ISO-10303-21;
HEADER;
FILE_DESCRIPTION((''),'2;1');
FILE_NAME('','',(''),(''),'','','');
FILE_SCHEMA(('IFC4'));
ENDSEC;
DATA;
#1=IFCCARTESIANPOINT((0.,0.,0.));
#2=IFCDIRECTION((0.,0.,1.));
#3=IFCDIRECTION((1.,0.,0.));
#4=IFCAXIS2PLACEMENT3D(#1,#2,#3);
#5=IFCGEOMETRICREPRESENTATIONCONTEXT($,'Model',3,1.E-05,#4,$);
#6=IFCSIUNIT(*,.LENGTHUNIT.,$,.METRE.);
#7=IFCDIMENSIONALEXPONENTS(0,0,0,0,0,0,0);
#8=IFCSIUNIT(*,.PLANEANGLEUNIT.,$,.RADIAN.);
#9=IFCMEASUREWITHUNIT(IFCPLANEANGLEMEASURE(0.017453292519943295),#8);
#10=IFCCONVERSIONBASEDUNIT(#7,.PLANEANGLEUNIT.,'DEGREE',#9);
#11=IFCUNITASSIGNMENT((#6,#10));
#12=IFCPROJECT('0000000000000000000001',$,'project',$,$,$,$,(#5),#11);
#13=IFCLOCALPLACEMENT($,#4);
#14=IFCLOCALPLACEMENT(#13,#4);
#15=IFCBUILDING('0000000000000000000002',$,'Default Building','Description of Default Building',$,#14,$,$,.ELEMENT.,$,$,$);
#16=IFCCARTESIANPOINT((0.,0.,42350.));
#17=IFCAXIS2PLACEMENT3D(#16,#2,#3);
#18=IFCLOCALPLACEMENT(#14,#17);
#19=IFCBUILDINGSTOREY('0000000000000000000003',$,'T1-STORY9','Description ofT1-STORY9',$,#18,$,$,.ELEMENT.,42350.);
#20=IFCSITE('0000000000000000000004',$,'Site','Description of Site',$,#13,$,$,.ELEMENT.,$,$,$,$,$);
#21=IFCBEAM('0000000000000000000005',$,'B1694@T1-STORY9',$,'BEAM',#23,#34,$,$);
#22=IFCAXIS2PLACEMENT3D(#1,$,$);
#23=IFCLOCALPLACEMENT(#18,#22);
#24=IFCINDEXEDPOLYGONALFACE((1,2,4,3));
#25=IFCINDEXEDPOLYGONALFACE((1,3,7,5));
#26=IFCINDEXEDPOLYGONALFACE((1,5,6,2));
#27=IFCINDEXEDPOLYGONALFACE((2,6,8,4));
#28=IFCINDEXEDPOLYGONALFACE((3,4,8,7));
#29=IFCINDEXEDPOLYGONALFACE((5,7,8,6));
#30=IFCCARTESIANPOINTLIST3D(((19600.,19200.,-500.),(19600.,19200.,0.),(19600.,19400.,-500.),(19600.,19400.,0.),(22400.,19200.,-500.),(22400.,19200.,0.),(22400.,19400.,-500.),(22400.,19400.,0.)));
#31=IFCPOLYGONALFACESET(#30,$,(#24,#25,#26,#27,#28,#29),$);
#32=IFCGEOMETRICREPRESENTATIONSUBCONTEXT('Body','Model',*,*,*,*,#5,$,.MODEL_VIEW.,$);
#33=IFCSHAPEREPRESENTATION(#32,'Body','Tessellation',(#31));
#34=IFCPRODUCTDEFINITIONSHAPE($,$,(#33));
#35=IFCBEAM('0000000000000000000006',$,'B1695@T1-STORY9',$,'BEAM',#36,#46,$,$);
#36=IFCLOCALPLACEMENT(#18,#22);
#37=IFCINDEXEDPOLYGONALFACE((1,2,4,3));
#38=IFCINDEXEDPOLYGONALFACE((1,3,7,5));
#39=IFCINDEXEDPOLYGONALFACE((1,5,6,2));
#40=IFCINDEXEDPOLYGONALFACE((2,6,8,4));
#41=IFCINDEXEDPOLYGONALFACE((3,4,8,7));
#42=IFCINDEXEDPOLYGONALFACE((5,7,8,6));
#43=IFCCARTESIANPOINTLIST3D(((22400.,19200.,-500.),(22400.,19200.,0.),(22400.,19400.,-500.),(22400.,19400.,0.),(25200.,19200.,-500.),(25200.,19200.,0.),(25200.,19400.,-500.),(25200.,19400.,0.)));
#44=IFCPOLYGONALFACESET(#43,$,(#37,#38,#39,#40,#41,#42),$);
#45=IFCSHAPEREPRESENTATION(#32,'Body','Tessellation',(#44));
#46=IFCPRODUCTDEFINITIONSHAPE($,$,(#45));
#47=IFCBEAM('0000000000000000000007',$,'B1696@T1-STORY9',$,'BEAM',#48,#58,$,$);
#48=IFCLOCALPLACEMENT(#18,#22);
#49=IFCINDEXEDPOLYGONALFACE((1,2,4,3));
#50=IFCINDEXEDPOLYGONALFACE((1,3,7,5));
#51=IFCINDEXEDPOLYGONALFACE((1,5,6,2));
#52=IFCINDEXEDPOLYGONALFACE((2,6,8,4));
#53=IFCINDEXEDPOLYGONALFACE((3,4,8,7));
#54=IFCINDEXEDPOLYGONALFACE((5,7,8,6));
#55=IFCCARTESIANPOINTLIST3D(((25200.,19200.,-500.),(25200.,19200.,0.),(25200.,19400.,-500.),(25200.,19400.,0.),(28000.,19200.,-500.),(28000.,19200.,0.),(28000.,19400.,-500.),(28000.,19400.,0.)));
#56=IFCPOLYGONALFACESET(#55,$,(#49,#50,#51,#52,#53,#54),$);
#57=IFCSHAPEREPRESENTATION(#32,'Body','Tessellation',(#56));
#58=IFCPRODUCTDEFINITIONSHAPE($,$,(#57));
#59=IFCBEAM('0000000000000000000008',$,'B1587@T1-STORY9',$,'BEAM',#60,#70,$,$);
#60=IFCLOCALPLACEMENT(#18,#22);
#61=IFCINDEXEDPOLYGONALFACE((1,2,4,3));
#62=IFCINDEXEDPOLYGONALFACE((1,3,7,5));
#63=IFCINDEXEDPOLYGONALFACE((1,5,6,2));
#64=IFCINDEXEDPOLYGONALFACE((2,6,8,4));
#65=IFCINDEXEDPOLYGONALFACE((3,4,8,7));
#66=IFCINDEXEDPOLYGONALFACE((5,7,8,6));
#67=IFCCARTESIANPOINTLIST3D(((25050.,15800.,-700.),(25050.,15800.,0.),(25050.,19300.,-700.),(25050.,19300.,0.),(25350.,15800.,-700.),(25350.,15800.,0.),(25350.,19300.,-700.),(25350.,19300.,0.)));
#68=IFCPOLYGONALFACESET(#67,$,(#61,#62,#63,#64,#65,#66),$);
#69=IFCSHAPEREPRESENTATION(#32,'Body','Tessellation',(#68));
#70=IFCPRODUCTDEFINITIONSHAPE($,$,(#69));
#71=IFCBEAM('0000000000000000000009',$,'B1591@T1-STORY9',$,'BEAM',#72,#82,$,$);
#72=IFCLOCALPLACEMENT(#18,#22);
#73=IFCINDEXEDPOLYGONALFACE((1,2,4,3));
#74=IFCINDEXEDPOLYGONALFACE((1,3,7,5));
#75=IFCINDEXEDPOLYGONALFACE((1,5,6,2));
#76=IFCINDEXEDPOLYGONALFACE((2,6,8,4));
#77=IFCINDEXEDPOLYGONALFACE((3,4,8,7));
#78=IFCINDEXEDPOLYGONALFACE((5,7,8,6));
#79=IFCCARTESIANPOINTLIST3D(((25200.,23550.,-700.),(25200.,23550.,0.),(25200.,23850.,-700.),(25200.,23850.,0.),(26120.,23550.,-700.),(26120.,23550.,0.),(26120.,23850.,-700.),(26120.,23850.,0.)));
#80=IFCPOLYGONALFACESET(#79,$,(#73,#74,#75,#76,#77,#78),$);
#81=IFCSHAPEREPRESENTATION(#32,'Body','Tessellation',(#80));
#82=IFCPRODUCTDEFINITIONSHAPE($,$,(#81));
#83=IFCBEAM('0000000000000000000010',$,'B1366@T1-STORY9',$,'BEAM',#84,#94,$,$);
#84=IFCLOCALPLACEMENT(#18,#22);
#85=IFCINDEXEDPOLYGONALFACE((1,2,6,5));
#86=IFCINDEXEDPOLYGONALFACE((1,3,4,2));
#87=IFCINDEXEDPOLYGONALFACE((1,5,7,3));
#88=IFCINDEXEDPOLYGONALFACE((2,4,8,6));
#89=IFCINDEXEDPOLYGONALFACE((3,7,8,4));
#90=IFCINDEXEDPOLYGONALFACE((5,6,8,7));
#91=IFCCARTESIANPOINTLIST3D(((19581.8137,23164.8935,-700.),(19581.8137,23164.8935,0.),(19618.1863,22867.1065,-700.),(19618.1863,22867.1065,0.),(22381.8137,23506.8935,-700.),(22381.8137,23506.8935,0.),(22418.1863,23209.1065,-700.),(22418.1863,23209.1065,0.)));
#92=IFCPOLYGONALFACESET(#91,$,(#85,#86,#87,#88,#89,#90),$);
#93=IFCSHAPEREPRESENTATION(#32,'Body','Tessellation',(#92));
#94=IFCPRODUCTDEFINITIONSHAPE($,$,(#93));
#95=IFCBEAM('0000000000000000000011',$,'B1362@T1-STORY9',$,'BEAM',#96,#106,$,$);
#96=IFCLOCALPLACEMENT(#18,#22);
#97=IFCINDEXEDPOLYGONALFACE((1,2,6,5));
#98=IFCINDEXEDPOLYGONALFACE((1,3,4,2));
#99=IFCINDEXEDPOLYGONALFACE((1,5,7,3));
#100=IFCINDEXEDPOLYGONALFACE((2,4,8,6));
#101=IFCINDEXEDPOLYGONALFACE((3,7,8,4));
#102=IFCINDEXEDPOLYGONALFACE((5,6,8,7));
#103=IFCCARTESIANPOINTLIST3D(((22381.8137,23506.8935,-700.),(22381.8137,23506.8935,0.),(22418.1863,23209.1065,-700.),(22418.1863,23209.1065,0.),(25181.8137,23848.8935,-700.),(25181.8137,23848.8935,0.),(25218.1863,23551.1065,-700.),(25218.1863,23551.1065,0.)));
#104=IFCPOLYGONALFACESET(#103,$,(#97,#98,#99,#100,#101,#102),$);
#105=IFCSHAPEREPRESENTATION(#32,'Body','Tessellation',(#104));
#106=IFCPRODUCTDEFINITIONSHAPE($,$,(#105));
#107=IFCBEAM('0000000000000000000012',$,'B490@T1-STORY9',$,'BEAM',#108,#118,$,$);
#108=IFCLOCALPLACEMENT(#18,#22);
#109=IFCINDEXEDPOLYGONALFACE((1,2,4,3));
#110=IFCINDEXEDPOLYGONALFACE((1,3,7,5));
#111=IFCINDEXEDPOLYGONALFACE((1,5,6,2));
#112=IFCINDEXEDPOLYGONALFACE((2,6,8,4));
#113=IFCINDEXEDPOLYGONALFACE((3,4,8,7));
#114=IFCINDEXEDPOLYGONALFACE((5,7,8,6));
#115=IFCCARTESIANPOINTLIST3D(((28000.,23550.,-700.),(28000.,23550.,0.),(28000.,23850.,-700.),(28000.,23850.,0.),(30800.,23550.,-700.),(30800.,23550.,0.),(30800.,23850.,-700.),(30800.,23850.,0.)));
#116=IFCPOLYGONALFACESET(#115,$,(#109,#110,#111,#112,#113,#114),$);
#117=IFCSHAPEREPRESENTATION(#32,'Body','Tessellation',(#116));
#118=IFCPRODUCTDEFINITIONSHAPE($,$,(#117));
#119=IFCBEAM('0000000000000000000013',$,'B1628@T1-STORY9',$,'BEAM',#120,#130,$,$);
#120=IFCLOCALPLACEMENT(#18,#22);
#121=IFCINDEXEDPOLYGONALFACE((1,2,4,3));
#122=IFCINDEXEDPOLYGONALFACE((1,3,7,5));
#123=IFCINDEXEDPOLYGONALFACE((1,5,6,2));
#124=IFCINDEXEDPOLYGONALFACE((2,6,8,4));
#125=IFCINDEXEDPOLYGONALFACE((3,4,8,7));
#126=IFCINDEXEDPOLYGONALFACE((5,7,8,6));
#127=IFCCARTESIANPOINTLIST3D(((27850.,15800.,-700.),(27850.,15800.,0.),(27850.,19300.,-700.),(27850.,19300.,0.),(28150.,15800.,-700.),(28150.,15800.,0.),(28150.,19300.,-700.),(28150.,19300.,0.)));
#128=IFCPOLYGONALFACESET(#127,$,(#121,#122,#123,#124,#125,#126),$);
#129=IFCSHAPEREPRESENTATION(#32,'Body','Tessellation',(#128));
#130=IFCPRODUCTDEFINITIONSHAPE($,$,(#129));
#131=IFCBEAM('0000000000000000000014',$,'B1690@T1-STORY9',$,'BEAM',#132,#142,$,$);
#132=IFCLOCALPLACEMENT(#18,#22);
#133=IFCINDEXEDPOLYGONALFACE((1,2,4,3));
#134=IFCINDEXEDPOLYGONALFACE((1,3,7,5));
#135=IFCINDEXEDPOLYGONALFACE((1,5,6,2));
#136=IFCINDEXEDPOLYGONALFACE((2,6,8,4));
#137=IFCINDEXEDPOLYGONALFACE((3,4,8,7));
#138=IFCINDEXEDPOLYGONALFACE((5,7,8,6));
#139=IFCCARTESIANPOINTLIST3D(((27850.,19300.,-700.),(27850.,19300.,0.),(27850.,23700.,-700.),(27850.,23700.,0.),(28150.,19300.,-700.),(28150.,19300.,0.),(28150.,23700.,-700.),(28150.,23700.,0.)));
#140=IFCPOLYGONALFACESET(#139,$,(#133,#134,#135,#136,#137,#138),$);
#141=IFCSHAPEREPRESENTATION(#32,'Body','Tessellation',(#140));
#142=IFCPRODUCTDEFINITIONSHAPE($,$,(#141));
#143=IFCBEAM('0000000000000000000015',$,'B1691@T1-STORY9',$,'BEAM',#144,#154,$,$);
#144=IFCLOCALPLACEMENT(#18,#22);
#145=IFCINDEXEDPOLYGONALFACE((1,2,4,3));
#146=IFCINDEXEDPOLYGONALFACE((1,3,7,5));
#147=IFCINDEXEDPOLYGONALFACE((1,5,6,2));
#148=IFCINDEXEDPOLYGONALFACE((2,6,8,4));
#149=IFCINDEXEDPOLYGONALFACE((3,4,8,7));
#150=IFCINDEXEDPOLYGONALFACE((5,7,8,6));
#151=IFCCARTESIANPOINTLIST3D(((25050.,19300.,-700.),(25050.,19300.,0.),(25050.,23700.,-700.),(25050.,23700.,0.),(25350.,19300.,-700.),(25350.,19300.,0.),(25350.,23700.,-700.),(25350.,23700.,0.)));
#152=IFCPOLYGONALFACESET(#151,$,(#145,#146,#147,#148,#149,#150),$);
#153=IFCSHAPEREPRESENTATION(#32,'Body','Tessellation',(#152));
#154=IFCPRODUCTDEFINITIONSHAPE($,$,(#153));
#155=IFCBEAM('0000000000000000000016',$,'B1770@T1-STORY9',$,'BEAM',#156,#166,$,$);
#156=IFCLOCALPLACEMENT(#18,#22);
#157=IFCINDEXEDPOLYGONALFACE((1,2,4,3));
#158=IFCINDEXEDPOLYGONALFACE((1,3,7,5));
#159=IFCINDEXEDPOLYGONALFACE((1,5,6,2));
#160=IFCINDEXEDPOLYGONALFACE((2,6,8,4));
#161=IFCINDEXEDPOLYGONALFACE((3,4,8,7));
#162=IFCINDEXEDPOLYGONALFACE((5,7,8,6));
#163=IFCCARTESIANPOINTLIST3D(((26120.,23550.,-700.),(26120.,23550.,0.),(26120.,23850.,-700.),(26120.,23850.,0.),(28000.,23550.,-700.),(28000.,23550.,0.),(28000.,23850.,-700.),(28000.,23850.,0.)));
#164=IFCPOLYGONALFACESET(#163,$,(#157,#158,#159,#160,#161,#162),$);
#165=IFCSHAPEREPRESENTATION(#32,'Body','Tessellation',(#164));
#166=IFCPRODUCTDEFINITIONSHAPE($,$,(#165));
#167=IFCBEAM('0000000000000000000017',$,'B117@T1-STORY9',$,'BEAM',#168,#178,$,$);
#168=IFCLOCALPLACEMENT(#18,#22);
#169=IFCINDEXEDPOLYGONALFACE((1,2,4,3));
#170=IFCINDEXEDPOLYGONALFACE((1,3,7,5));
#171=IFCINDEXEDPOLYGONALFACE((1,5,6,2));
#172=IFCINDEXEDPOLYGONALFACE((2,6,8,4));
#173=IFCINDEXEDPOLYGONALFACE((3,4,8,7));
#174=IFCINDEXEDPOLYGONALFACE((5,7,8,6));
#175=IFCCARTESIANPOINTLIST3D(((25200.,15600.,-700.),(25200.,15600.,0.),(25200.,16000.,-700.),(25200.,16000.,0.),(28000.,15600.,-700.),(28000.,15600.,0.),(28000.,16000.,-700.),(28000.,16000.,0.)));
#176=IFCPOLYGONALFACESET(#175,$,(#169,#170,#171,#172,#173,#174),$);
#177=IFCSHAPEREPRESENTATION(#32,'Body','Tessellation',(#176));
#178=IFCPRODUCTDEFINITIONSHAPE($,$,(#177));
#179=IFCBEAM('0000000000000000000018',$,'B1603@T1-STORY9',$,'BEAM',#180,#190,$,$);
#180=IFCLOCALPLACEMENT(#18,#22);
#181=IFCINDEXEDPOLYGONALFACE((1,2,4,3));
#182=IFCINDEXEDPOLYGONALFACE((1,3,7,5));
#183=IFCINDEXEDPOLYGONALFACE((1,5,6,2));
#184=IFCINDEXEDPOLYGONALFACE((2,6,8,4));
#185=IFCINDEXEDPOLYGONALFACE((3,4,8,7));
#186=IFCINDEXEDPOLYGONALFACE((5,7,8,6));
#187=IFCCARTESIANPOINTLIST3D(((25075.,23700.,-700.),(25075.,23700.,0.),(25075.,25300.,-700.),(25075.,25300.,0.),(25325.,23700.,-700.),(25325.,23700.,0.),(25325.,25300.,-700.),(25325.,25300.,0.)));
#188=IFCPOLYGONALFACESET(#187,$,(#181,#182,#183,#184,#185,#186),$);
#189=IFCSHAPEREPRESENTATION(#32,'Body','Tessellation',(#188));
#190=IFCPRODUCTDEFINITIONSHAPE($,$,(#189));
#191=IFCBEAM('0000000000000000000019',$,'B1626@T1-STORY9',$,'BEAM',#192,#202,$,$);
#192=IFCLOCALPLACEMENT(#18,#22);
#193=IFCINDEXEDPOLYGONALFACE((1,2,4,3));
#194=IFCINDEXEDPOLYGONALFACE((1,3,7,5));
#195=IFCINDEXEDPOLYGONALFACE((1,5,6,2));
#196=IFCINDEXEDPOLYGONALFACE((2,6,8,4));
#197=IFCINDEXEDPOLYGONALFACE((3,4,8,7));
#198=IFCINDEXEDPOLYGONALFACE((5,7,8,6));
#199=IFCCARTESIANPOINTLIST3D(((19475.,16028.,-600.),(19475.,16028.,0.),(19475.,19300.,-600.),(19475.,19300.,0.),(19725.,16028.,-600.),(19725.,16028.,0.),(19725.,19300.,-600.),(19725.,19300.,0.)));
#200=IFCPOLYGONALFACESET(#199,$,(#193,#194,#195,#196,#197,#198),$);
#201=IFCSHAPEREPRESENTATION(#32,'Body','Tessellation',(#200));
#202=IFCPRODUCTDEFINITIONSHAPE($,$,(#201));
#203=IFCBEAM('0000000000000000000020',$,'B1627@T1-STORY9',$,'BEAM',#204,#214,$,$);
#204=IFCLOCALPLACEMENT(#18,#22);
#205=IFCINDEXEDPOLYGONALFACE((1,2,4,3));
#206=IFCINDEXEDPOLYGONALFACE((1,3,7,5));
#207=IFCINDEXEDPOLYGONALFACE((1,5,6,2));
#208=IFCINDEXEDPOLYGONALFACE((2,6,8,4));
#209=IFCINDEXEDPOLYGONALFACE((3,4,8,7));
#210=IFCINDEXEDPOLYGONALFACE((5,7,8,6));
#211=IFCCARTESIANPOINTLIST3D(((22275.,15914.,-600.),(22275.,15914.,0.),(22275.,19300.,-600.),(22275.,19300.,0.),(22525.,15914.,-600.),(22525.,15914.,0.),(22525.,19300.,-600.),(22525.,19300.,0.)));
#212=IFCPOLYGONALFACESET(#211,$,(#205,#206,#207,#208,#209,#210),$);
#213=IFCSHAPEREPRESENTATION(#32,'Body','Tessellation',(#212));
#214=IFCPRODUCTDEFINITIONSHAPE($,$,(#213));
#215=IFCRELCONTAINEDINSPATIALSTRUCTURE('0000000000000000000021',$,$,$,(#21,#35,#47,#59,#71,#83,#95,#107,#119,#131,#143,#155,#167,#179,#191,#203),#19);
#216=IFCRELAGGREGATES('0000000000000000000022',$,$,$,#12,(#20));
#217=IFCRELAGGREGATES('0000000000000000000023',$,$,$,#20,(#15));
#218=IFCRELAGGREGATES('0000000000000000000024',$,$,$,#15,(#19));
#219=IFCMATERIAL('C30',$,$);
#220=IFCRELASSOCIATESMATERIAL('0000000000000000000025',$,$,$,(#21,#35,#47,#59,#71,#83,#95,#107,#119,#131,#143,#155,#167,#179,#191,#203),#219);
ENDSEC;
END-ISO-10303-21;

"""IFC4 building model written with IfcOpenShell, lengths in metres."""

from ifc_helpers import new_model, entity, si_unit, converted_unit, frame, origin_with_axes, place, context, subcontext, project, spatial, rectangle, extrude, material, element, save


model = new_model("IFC4")

# Units and contexts
model_context = context("Model", 3, precision=1e-05, world=origin_with_axes())
body_context = subcontext(model_context, "Body", "Model", "MODEL_VIEW")
ifc_project = project(units=[si_unit("LENGTHUNIT", "METRE"), converted_unit("PLANEANGLEUNIT", "DEGREE", entity("IfcPlaneAngleMeasure", 0.017453292519943295), si_unit("PLANEANGLEUNIT", "RADIAN"), dimensions=[0, 0, 0, 0, 0, 0, 0])], contexts=[model_context])

# Site, building, storey
site_placement = place(None, origin_with_axes())
site = spatial("IfcSite", under=ifc_project, at=site_placement, Name="Site", Description="Description of Site", CompositionType="ELEMENT")
building_placement = place(site_placement, origin_with_axes())
building = spatial("IfcBuilding", under=site, at=building_placement, Name="Default Building", Description="Description of Default Building", CompositionType="ELEMENT")
storey_placement = place(building_placement, frame((0.0, 0.0, 42350.0), z_axis=(0.0, 0.0, 1.0), x_axis=(1.0, 0.0, 0.0)))
storey = spatial("IfcBuildingStorey", under=building, at=storey_placement, Name="T1-STORY9", Description="Description ofT1-STORY9", CompositionType="ELEMENT", Elevation=42350.0)

# Beams
ifc_material_1 = material(Name="C30")
for number, where, z_axis, x_axis, name in (
    (1, (19600.0, 19300.0, -250.0), (1.0, 0.0, 0.0), (0.0, 1.0, 0.0), "B1694@T1-STORY9"),
    (2, (22400.0, 19300.0, -250.0), (1.0, 0.0, 0.0), (0.0, 1.0, 0.0), "B1695@T1-STORY9"),
    (3, (25200.0, 19300.0, -250.0), (1.0, 0.0, 0.0), (0.0, 1.0, 0.0), "B1696@T1-STORY9"),
):
    element("IfcBeam", number, at=place(storey_placement, frame(where, z_axis=z_axis, x_axis=x_axis)), inside=storey, material=ifc_material_1, Name=name, ObjectType="BEAM", context=body_context, shape_type="SweptSolid", body=[
        extrude(rectangle(XDim=200.0, YDim=500.0), origin_with_axes(), (0.0, 0.0, 1.0), 2800.0),
    ])
beam_1_placement = place(storey_placement, frame((25200.0, 15800.0, -350.0), z_axis=(0.0, 1.0, 0.0), x_axis=(-1.0, 0.0, 0.0)))
element("IfcBeam", 4, at=beam_1_placement, inside=storey, material=ifc_material_1, Name="B1587@T1-STORY9", ObjectType="BEAM", context=body_context, shape_type="SweptSolid", body=[
    extrude(rectangle(XDim=300.0, YDim=700.0), origin_with_axes(), (0.0, 0.0, 1.0), 3500.0),
])
beam_2_placement = place(storey_placement, frame((25200.0, 23700.0, -350.0), z_axis=(1.0, 0.0, 0.0), x_axis=(0.0, 1.0, 0.0)))
element("IfcBeam", 5, at=beam_2_placement, inside=storey, material=ifc_material_1, Name="B1591@T1-STORY9", ObjectType="BEAM", context=body_context, shape_type="SweptSolid", body=[
    extrude(rectangle(XDim=300.0, YDim=700.0), origin_with_axes(), (0.0, 0.0, 1.0), 920.0),
])
for number, where, z_axis, x_axis, name in (
    (6, (19600.0, 23016.0, -350.0), (0.992623, 0.121242, 0.0), (-0.121242, 0.992623, 0.0), "B1366@T1-STORY9"),
    (7, (22400.0, 23358.0, -350.0), (0.992623, 0.121242, 0.0), (-0.121242, 0.992623, 0.0), "B1362@T1-STORY9"),
):
    element("IfcBeam", number, at=place(storey_placement, frame(where, z_axis=z_axis, x_axis=x_axis)), inside=storey, material=ifc_material_1, Name=name, ObjectType="BEAM", context=body_context, shape_type="SweptSolid", body=[
        extrude(rectangle(XDim=300.0, YDim=700.0), origin_with_axes(), (0.0, 0.0, 1.0), 2820.8091),
    ])
beam_3_placement = place(storey_placement, frame((28000.0, 23700.0, -350.0), z_axis=(1.0, 0.0, 0.0), x_axis=(0.0, 1.0, 0.0)))
element("IfcBeam", 8, at=beam_3_placement, inside=storey, material=ifc_material_1, Name="B490@T1-STORY9", ObjectType="BEAM", context=body_context, shape_type="SweptSolid", body=[
    extrude(rectangle(XDim=300.0, YDim=700.0), origin_with_axes(), (0.0, 0.0, 1.0), 2800.0),
])
beam_4_placement = place(storey_placement, frame((28000.0, 15800.0, -350.0), z_axis=(0.0, 1.0, 0.0), x_axis=(-1.0, 0.0, 0.0)))
element("IfcBeam", 9, at=beam_4_placement, inside=storey, material=ifc_material_1, Name="B1628@T1-STORY9", ObjectType="BEAM", context=body_context, shape_type="SweptSolid", body=[
    extrude(rectangle(XDim=300.0, YDim=700.0), origin_with_axes(), (0.0, 0.0, 1.0), 3500.0),
])
for number, where, z_axis, x_axis, name in (
    (10, (28000.0, 19300.0, -350.0), (0.0, 1.0, 0.0), (-1.0, 0.0, 0.0), "B1690@T1-STORY9"),
    (11, (25200.0, 19300.0, -350.0), (0.0, 1.0, 0.0), (-1.0, 0.0, 0.0), "B1691@T1-STORY9"),
):
    element("IfcBeam", number, at=place(storey_placement, frame(where, z_axis=z_axis, x_axis=x_axis)), inside=storey, material=ifc_material_1, Name=name, ObjectType="BEAM", context=body_context, shape_type="SweptSolid", body=[
        extrude(rectangle(XDim=300.0, YDim=700.0), origin_with_axes(), (0.0, 0.0, 1.0), 4400.0),
    ])
beam_5_placement = place(storey_placement, frame((26120.0, 23700.0, -350.0), z_axis=(1.0, 0.0, 0.0), x_axis=(0.0, 1.0, 0.0)))
element("IfcBeam", 12, at=beam_5_placement, inside=storey, material=ifc_material_1, Name="B1770@T1-STORY9", ObjectType="BEAM", context=body_context, shape_type="SweptSolid", body=[
    extrude(rectangle(XDim=300.0, YDim=700.0), origin_with_axes(), (0.0, 0.0, 1.0), 1880.0),
])
beam_6_placement = place(storey_placement, frame((25200.0, 15800.0, -350.0), z_axis=(1.0, 0.0, 0.0), x_axis=(0.0, 1.0, 0.0)))
element("IfcBeam", 13, at=beam_6_placement, inside=storey, material=ifc_material_1, Name="B117@T1-STORY9", ObjectType="BEAM", context=body_context, shape_type="SweptSolid", body=[
    extrude(rectangle(XDim=400.0, YDim=700.0), origin_with_axes(), (0.0, 0.0, 1.0), 2800.0),
])
beam_7_placement = place(storey_placement, frame((25200.0, 23700.0, -350.0), z_axis=(0.0, 1.0, 0.0), x_axis=(-1.0, 0.0, 0.0)))
element("IfcBeam", 14, at=beam_7_placement, inside=storey, material=ifc_material_1, Name="B1603@T1-STORY9", ObjectType="BEAM", context=body_context, shape_type="SweptSolid", body=[
    extrude(rectangle(XDim=250.0, YDim=700.0), origin_with_axes(), (0.0, 0.0, 1.0), 1600.0),
])
beam_8_placement = place(storey_placement, frame((19600.0, 16028.0, -300.0), z_axis=(0.0, 1.0, 0.0), x_axis=(-1.0, 0.0, 0.0)))
element("IfcBeam", 15, at=beam_8_placement, inside=storey, material=ifc_material_1, Name="B1626@T1-STORY9", ObjectType="BEAM", context=body_context, shape_type="SweptSolid", body=[
    extrude(rectangle(XDim=250.0, YDim=600.0), origin_with_axes(), (0.0, 0.0, 1.0), 3272.0),
])
beam_9_placement = place(storey_placement, frame((22400.0, 15914.0, -300.0), z_axis=(0.0, 1.0, 0.0), x_axis=(-1.0, 0.0, 0.0)))
element("IfcBeam", 16, at=beam_9_placement, inside=storey, material=ifc_material_1, Name="B1627@T1-STORY9", ObjectType="BEAM", context=body_context, shape_type="SweptSolid", body=[
    extrude(rectangle(XDim=250.0, YDim=600.0), origin_with_axes(), (0.0, 0.0, 1.0), 3386.0),
])

save(model, "model.ifc")
